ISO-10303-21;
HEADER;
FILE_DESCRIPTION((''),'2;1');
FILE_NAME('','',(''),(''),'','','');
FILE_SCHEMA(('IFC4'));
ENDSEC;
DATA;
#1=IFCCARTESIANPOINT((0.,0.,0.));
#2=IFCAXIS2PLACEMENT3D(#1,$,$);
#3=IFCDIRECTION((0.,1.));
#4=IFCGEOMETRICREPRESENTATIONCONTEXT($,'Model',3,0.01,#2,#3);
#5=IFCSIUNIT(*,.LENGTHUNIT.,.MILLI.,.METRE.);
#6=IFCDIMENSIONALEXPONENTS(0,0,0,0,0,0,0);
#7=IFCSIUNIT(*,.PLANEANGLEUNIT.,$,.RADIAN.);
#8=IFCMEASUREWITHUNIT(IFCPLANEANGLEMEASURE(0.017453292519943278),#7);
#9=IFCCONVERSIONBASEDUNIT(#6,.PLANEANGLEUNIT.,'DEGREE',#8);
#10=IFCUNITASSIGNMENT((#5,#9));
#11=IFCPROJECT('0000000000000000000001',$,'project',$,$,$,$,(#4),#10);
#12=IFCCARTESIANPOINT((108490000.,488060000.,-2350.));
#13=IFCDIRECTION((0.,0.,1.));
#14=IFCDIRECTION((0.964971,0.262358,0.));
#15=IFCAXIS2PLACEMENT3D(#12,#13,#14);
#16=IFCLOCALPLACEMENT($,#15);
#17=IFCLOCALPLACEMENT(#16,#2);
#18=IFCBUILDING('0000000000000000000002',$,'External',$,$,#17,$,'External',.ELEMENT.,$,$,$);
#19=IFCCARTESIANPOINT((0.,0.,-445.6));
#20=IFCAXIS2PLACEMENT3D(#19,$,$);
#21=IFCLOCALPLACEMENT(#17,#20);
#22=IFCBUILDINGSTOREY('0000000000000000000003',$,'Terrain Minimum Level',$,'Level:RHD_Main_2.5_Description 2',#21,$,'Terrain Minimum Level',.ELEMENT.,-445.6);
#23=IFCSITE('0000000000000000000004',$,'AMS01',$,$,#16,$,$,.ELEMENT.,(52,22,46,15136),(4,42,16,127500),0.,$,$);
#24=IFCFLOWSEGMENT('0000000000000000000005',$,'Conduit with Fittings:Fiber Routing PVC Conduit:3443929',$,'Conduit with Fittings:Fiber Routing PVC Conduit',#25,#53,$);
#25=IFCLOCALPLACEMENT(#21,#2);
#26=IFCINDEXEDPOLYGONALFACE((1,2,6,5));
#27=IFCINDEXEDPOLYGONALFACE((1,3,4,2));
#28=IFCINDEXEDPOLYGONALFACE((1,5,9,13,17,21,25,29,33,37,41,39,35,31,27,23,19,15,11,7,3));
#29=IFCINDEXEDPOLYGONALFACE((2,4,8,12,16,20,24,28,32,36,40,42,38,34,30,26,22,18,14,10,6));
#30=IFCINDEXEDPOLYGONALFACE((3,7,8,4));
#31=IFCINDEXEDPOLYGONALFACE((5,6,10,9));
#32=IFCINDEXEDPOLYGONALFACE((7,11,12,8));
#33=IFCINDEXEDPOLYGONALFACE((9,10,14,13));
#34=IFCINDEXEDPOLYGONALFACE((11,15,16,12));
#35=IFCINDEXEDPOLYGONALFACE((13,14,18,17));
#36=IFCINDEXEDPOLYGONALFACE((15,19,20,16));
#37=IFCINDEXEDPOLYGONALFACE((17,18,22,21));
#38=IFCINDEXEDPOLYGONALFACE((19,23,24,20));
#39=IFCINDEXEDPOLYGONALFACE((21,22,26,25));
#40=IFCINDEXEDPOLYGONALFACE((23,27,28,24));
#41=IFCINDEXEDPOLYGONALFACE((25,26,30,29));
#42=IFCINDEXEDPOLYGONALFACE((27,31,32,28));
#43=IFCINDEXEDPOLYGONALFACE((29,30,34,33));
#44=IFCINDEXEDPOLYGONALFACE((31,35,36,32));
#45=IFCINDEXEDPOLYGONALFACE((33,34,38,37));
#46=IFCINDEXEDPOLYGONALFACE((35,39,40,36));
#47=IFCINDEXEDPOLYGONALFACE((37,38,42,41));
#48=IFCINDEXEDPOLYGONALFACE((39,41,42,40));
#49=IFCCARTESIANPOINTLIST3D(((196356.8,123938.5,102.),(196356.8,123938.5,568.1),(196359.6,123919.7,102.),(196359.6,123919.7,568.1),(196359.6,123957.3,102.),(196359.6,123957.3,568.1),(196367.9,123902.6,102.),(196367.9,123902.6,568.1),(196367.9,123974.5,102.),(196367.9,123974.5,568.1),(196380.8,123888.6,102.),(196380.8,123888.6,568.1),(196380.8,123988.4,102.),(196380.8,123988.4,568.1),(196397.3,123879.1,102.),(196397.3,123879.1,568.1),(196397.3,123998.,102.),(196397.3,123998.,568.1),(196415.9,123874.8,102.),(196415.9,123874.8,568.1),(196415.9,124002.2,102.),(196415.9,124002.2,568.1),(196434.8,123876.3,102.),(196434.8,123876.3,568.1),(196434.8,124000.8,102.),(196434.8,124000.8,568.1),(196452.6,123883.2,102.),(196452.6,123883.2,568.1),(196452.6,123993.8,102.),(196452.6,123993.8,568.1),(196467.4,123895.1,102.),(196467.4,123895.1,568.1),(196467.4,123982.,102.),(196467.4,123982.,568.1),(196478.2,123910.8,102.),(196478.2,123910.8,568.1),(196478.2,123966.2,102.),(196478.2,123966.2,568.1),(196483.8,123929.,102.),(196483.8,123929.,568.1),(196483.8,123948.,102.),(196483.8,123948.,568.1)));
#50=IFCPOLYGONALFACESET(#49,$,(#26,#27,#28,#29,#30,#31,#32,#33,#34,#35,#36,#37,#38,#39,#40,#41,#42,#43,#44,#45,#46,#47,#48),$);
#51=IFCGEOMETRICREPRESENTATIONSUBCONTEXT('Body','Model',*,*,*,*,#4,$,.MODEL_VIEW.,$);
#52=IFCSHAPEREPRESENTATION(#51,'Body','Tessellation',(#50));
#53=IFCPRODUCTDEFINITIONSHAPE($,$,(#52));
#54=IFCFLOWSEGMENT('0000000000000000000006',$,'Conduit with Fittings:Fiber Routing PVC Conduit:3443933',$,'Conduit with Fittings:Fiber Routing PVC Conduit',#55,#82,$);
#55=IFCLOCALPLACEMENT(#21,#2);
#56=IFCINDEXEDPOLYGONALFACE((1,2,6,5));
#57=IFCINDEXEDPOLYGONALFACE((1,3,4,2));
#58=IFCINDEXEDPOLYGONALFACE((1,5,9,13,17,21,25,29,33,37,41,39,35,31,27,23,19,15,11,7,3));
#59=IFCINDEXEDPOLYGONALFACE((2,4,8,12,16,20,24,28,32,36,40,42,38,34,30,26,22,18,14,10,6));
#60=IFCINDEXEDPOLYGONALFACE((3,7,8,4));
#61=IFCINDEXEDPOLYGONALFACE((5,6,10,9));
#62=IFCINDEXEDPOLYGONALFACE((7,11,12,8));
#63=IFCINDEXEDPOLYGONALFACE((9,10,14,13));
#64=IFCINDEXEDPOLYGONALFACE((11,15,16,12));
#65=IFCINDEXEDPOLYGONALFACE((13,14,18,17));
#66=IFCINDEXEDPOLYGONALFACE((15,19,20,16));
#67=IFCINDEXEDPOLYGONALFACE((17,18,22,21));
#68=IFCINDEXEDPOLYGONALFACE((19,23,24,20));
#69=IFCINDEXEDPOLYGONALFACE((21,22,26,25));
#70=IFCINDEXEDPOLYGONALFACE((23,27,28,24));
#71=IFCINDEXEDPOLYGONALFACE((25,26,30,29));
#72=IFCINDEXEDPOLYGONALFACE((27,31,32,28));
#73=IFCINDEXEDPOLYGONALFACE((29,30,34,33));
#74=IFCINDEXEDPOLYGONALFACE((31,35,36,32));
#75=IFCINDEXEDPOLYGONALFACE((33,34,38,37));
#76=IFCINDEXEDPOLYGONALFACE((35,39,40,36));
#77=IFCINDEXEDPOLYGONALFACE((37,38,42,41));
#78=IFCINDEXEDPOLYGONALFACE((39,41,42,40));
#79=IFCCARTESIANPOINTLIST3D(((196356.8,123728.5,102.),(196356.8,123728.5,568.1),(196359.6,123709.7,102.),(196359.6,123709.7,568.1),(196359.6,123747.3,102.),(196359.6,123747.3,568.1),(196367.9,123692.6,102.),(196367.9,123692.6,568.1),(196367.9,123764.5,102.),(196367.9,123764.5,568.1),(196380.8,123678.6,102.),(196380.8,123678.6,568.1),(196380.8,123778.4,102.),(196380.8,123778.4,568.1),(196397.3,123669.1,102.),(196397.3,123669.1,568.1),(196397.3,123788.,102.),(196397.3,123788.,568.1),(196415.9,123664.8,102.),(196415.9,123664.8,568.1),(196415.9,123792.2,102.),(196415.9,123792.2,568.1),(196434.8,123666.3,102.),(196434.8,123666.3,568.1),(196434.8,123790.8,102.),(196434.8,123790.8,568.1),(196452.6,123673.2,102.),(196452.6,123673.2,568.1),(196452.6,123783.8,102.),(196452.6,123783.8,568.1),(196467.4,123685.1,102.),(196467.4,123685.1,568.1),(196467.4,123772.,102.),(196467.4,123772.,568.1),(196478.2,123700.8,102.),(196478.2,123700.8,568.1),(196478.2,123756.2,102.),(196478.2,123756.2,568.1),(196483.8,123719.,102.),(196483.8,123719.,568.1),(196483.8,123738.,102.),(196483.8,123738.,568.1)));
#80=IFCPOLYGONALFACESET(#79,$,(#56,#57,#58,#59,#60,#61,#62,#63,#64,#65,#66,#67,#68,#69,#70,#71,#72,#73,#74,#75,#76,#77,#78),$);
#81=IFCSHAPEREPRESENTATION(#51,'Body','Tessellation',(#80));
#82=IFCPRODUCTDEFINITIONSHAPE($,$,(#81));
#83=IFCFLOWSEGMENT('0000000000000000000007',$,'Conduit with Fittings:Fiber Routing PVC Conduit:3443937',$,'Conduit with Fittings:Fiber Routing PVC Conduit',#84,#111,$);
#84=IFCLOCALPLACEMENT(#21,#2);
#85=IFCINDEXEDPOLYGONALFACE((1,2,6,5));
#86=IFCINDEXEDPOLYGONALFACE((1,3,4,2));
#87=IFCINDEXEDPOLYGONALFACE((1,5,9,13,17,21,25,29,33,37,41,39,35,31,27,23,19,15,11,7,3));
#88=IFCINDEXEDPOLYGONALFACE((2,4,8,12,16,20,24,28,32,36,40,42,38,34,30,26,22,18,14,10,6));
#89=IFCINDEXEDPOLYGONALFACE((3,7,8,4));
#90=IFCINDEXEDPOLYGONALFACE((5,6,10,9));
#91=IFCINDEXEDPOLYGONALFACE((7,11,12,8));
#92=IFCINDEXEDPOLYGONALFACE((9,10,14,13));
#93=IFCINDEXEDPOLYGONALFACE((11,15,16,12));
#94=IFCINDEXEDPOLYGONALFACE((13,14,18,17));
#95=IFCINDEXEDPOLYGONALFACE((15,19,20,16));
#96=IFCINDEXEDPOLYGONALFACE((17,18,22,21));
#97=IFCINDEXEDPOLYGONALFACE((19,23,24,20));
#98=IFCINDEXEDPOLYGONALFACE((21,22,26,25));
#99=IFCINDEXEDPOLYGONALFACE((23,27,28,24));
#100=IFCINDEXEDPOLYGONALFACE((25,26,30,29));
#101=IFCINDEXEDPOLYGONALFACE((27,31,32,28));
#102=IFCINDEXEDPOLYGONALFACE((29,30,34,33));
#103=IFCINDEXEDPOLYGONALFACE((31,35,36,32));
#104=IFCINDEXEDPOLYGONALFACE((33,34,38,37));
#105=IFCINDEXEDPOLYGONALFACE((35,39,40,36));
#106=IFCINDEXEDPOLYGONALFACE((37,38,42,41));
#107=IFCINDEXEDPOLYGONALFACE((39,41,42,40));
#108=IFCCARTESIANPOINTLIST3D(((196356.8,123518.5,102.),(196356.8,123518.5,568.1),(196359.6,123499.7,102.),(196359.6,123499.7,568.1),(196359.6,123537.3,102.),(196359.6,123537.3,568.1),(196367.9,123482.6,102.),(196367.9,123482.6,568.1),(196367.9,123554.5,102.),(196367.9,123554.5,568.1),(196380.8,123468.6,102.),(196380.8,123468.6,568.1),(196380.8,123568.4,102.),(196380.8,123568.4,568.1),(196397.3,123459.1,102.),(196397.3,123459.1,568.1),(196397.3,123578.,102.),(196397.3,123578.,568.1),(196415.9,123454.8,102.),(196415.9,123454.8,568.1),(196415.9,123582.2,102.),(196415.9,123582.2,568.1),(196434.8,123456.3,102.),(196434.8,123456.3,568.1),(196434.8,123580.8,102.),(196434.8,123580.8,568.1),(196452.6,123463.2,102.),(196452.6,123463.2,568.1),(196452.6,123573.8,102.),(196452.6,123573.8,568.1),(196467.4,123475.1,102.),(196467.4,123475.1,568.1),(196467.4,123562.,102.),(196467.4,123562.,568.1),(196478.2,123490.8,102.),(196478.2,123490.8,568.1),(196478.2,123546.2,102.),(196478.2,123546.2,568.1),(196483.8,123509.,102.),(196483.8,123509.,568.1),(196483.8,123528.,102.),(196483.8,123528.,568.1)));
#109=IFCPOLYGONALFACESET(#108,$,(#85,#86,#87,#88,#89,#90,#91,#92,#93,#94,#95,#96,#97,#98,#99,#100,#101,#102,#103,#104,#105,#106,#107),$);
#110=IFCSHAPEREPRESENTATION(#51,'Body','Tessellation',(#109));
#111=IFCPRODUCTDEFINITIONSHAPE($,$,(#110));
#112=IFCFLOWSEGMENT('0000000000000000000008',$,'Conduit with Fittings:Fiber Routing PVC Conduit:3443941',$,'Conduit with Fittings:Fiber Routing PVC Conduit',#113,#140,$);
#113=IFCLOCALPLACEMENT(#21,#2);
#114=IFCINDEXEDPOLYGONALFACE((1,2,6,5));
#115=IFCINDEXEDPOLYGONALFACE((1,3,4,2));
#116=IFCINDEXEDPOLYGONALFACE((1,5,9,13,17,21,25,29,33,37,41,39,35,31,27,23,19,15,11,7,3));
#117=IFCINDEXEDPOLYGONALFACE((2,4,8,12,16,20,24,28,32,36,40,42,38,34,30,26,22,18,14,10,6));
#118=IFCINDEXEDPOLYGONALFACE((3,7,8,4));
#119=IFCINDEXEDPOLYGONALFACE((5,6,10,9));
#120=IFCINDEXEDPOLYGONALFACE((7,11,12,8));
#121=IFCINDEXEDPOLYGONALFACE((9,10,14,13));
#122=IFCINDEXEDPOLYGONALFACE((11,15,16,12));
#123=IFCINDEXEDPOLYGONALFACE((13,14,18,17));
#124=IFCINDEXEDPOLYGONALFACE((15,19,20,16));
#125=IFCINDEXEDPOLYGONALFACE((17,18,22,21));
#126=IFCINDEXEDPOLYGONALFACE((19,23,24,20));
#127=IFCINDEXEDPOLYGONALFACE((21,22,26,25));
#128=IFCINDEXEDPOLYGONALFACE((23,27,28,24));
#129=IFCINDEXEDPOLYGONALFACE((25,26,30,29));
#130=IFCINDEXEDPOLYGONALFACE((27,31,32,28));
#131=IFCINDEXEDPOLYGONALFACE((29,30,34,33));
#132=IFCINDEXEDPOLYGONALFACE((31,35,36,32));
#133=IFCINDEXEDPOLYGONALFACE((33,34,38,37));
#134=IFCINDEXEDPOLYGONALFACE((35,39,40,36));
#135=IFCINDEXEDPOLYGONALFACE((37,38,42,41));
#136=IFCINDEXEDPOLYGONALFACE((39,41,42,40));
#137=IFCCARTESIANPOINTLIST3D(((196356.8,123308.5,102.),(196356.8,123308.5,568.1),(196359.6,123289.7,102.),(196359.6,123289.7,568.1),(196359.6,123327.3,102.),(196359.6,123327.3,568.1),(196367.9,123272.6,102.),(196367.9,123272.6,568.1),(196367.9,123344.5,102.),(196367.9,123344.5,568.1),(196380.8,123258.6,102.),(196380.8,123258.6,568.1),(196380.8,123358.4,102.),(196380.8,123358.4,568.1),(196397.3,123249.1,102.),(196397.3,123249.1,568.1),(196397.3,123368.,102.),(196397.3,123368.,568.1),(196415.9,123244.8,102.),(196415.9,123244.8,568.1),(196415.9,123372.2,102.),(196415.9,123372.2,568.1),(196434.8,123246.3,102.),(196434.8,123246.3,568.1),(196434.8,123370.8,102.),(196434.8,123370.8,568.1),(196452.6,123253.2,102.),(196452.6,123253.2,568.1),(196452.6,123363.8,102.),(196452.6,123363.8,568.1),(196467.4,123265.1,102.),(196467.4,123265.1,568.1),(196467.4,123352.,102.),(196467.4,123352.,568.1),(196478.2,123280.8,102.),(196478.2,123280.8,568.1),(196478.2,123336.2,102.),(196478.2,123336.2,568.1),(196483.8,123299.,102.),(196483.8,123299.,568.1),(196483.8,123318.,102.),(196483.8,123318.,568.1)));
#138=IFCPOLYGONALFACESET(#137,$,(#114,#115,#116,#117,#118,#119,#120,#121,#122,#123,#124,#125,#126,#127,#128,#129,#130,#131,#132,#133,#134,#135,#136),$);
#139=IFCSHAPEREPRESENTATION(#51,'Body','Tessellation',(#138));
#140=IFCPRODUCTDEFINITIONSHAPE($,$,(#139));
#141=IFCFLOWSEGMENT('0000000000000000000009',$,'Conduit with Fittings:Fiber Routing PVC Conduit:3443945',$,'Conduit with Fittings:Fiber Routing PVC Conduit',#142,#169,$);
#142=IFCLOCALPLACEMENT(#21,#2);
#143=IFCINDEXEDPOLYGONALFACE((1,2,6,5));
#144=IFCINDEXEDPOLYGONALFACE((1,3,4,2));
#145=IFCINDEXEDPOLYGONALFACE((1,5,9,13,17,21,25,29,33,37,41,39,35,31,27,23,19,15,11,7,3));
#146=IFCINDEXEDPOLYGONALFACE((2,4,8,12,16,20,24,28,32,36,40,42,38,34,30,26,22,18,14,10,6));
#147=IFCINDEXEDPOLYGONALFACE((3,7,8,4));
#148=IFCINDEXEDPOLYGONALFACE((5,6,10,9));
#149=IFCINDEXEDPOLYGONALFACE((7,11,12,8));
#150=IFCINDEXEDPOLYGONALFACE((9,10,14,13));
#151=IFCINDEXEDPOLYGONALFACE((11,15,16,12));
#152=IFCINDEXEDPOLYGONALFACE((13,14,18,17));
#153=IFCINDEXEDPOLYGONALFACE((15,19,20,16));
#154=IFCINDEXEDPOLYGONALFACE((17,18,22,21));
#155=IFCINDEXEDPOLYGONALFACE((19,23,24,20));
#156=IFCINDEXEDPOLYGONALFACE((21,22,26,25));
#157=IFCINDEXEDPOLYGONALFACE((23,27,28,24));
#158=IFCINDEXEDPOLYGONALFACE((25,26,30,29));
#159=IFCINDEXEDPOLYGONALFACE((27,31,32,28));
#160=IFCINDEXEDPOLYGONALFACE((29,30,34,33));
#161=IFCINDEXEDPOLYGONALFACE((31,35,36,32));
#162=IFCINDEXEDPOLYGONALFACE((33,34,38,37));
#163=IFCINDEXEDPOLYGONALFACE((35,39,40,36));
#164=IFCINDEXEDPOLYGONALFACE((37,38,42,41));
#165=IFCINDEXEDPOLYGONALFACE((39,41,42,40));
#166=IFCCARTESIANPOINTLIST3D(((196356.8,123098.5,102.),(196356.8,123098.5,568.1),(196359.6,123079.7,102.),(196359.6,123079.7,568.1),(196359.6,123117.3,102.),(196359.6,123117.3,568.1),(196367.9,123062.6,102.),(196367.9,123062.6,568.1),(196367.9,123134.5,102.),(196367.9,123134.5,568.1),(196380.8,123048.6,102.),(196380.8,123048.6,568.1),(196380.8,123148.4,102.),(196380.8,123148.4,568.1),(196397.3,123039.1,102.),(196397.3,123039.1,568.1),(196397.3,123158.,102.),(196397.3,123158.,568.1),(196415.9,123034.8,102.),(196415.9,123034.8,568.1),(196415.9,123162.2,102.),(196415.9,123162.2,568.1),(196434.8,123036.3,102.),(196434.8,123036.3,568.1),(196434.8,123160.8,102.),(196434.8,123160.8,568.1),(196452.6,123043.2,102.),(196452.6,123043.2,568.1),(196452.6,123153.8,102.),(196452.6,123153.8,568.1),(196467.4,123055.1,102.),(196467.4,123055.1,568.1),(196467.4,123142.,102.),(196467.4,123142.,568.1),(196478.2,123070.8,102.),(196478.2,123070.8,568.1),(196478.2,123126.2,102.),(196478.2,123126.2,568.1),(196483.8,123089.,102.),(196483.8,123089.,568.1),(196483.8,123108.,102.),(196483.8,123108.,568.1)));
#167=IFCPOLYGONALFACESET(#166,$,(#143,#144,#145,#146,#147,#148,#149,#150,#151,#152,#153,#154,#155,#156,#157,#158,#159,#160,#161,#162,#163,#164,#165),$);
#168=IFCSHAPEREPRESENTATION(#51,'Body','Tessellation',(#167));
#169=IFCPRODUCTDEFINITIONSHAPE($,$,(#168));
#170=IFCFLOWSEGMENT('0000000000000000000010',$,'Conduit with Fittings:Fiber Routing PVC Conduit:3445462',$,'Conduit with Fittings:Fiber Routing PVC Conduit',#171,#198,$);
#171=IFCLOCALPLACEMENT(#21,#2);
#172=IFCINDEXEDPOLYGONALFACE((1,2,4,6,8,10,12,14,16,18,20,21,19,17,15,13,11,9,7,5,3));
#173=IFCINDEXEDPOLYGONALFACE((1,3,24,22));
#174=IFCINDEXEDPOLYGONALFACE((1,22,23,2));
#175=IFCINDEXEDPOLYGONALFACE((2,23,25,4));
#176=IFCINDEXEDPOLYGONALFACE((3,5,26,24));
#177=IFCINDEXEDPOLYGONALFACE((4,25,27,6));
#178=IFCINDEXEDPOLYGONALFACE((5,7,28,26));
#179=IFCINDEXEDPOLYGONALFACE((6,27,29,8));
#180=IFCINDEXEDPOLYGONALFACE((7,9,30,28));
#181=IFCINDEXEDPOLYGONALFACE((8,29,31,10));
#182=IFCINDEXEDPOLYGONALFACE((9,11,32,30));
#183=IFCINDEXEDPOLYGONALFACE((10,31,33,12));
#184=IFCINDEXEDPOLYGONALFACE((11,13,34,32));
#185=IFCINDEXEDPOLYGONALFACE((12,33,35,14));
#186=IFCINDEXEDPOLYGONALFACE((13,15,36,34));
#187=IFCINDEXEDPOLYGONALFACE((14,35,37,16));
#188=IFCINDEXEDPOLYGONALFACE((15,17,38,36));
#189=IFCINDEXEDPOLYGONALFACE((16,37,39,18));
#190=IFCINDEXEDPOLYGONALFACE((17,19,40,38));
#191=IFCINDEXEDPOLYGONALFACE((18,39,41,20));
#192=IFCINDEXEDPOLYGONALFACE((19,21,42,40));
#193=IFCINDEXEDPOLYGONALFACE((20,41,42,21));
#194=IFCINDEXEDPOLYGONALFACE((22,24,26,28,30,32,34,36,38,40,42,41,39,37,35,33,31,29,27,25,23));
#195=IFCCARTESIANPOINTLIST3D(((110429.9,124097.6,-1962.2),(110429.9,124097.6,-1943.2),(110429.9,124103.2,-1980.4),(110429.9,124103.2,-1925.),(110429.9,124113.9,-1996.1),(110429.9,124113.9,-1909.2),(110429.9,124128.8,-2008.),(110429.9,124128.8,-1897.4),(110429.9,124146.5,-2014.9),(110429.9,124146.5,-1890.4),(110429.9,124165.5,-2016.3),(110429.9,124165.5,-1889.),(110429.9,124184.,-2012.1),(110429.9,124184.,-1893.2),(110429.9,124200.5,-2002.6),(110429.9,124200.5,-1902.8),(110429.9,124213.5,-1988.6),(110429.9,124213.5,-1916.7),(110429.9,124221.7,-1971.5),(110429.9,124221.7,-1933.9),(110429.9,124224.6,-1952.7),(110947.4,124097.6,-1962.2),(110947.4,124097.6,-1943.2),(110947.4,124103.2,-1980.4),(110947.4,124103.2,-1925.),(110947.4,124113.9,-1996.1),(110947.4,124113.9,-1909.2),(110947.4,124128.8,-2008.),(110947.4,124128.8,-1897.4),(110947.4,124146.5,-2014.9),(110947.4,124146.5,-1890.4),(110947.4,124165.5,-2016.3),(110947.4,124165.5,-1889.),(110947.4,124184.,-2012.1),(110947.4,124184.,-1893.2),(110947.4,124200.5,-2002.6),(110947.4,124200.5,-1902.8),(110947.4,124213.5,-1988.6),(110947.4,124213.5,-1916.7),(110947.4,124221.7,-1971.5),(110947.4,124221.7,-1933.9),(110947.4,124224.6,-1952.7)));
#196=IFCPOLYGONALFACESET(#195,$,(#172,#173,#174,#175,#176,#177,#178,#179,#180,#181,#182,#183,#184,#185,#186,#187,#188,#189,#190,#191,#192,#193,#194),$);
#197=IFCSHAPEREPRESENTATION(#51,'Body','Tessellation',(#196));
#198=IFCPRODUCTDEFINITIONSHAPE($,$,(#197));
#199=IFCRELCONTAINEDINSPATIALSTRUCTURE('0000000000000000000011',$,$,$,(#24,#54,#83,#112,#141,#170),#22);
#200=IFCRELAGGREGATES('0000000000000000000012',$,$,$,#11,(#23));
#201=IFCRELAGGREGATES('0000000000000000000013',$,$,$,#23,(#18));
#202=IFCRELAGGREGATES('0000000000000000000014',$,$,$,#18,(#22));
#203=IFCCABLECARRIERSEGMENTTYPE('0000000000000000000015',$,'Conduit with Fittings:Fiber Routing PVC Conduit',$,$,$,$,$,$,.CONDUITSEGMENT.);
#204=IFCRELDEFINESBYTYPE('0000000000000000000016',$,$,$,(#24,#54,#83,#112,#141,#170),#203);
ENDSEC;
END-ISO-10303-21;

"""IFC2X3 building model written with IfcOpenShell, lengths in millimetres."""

from ifc_helpers import new_model, entity, si_unit, converted_unit, direction, frame, frame_2d, origin, origin_2d_with_axis, place, context, subcontext, project, spatial, circle, extrude, type_object, element, save


model = new_model("IFC2X3")

# Units and contexts
model_context = context("Model", 3, precision=0.01, world=origin(), true_north=direction((0.0, 1.0)))
body_context = subcontext(model_context, "Body", "Model", "MODEL_VIEW")
ifc_project = project(units=[si_unit("LENGTHUNIT", "METRE", prefix="MILLI"), converted_unit("PLANEANGLEUNIT", "DEGREE", entity("IfcPlaneAngleMeasure", 0.017453292519943278), si_unit("PLANEANGLEUNIT", "RADIAN"), dimensions=[0, 0, 0, 0, 0, 0, 0])], contexts=[model_context])

# Site, building, storey
site_placement = place(None, frame((108490000.0, 488060000.0, -2350.0), z_axis=(0.0, 0.0, 1.0), x_axis=(0.964971, 0.262358, 0.0)))
site = spatial("IfcSite", under=ifc_project, at=site_placement, Name="AMS01", CompositionType="ELEMENT", RefLatitude=(52, 22, 46, 15136), RefLongitude=(4, 42, 16, 127500), RefElevation=0.0)
building_placement = place(site_placement, origin())
building = spatial("IfcBuilding", under=site, at=building_placement, Name="External", LongName="External", CompositionType="ELEMENT")
storey_placement = place(building_placement, frame((0.0, 0.0, -445.6)))
storey = spatial("IfcBuildingStorey", under=building, at=storey_placement, Name="Terrain Minimum Level", ObjectType="Level:RHD_Main_2.5_Description 2", LongName="Terrain Minimum Level", CompositionType="ELEMENT", Elevation=-445.6)

# Flow segments
cable_carrier_segment_type = type_object("IfcCableCarrierSegmentType", Name="Conduit with Fittings:Fiber Routing PVC Conduit", PredefinedType="CONDUITSEGMENT")
flow_segment_1_placement = place(storey_placement, origin())
element("IfcFlowSegment", 1, at=flow_segment_1_placement, inside=storey, type_object=cable_carrier_segment_type, Name="Conduit with Fittings:Fiber Routing PVC Conduit:3443929", ObjectType="Conduit with Fittings:Fiber Routing PVC Conduit", context=body_context, shape_type="SweptSolid", body=[
    extrude(circle(Radius=63.9, at=origin_2d_with_axis()), frame((196420.6, 123938.5, 102.0), z_axis=(0.0, 0.0, 1.0), x_axis=(-1.0, 0.0, 0.0)), (0.0, 0.0, 1.0), 466.1),
])
flow_segment_2_placement = place(storey_placement, origin())
element("IfcFlowSegment", 2, at=flow_segment_2_placement, inside=storey, type_object=cable_carrier_segment_type, Name="Conduit with Fittings:Fiber Routing PVC Conduit:3443933", ObjectType="Conduit with Fittings:Fiber Routing PVC Conduit", context=body_context, shape_type="SweptSolid", body=[
    extrude(circle(Radius=63.9, at=origin_2d_with_axis()), frame((196420.6, 123728.5, 102.0), z_axis=(0.0, 0.0, 1.0), x_axis=(-1.0, 0.0, 0.0)), (0.0, 0.0, 1.0), 466.1),
])
flow_segment_3_placement = place(storey_placement, origin())
element("IfcFlowSegment", 3, at=flow_segment_3_placement, inside=storey, type_object=cable_carrier_segment_type, Name="Conduit with Fittings:Fiber Routing PVC Conduit:3443937", ObjectType="Conduit with Fittings:Fiber Routing PVC Conduit", context=body_context, shape_type="SweptSolid", body=[
    extrude(circle(Radius=63.9, at=frame_2d((0.0, 0.0), x_axis=(1.0, 0.0))), frame((196420.6, 123518.5, 102.0), z_axis=(0.0, 0.0, 1.0), x_axis=(-1.0, 0.0, 0.0)), (0.0, 0.0, 1.0), 466.1),
])
flow_segment_4_placement = place(storey_placement, origin())
element("IfcFlowSegment", 4, at=flow_segment_4_placement, inside=storey, type_object=cable_carrier_segment_type, Name="Conduit with Fittings:Fiber Routing PVC Conduit:3443941", ObjectType="Conduit with Fittings:Fiber Routing PVC Conduit", context=body_context, shape_type="SweptSolid", body=[
    extrude(circle(Radius=63.9, at=frame_2d((0.0, 0.0), x_axis=(1.0, 0.0))), frame((196420.6, 123308.5, 102.0), z_axis=(0.0, 0.0, 1.0), x_axis=(-1.0, 0.0, 0.0)), (0.0, 0.0, 1.0), 466.1),
])
flow_segment_5_placement = place(storey_placement, origin())
element("IfcFlowSegment", 5, at=flow_segment_5_placement, inside=storey, type_object=cable_carrier_segment_type, Name="Conduit with Fittings:Fiber Routing PVC Conduit:3443945", ObjectType="Conduit with Fittings:Fiber Routing PVC Conduit", context=body_context, shape_type="SweptSolid", body=[
    extrude(circle(Radius=63.9, at=origin_2d_with_axis()), frame((196420.6, 123098.5, 102.0), z_axis=(0.0, 0.0, 1.0), x_axis=(-1.0, 0.0, 0.0)), (0.0, 0.0, 1.0), 466.1),
])
flow_segment_6_placement = place(storey_placement, origin())
element("IfcFlowSegment", 6, at=flow_segment_6_placement, inside=storey, type_object=cable_carrier_segment_type, Name="Conduit with Fittings:Fiber Routing PVC Conduit:3445462", ObjectType="Conduit with Fittings:Fiber Routing PVC Conduit", context=body_context, shape_type="SweptSolid", body=[
    extrude(circle(Radius=63.9, at=frame_2d((0.0, 0.0), x_axis=(1.0, 0.0))), frame((110429.9, 124160.7, -1952.7), z_axis=(1.0, 0.0, 0.0), x_axis=(0.0, 1.0, 0.0)), (0.0, 0.0, 1.0), 517.5),
])

save(model, "model.ifc")
